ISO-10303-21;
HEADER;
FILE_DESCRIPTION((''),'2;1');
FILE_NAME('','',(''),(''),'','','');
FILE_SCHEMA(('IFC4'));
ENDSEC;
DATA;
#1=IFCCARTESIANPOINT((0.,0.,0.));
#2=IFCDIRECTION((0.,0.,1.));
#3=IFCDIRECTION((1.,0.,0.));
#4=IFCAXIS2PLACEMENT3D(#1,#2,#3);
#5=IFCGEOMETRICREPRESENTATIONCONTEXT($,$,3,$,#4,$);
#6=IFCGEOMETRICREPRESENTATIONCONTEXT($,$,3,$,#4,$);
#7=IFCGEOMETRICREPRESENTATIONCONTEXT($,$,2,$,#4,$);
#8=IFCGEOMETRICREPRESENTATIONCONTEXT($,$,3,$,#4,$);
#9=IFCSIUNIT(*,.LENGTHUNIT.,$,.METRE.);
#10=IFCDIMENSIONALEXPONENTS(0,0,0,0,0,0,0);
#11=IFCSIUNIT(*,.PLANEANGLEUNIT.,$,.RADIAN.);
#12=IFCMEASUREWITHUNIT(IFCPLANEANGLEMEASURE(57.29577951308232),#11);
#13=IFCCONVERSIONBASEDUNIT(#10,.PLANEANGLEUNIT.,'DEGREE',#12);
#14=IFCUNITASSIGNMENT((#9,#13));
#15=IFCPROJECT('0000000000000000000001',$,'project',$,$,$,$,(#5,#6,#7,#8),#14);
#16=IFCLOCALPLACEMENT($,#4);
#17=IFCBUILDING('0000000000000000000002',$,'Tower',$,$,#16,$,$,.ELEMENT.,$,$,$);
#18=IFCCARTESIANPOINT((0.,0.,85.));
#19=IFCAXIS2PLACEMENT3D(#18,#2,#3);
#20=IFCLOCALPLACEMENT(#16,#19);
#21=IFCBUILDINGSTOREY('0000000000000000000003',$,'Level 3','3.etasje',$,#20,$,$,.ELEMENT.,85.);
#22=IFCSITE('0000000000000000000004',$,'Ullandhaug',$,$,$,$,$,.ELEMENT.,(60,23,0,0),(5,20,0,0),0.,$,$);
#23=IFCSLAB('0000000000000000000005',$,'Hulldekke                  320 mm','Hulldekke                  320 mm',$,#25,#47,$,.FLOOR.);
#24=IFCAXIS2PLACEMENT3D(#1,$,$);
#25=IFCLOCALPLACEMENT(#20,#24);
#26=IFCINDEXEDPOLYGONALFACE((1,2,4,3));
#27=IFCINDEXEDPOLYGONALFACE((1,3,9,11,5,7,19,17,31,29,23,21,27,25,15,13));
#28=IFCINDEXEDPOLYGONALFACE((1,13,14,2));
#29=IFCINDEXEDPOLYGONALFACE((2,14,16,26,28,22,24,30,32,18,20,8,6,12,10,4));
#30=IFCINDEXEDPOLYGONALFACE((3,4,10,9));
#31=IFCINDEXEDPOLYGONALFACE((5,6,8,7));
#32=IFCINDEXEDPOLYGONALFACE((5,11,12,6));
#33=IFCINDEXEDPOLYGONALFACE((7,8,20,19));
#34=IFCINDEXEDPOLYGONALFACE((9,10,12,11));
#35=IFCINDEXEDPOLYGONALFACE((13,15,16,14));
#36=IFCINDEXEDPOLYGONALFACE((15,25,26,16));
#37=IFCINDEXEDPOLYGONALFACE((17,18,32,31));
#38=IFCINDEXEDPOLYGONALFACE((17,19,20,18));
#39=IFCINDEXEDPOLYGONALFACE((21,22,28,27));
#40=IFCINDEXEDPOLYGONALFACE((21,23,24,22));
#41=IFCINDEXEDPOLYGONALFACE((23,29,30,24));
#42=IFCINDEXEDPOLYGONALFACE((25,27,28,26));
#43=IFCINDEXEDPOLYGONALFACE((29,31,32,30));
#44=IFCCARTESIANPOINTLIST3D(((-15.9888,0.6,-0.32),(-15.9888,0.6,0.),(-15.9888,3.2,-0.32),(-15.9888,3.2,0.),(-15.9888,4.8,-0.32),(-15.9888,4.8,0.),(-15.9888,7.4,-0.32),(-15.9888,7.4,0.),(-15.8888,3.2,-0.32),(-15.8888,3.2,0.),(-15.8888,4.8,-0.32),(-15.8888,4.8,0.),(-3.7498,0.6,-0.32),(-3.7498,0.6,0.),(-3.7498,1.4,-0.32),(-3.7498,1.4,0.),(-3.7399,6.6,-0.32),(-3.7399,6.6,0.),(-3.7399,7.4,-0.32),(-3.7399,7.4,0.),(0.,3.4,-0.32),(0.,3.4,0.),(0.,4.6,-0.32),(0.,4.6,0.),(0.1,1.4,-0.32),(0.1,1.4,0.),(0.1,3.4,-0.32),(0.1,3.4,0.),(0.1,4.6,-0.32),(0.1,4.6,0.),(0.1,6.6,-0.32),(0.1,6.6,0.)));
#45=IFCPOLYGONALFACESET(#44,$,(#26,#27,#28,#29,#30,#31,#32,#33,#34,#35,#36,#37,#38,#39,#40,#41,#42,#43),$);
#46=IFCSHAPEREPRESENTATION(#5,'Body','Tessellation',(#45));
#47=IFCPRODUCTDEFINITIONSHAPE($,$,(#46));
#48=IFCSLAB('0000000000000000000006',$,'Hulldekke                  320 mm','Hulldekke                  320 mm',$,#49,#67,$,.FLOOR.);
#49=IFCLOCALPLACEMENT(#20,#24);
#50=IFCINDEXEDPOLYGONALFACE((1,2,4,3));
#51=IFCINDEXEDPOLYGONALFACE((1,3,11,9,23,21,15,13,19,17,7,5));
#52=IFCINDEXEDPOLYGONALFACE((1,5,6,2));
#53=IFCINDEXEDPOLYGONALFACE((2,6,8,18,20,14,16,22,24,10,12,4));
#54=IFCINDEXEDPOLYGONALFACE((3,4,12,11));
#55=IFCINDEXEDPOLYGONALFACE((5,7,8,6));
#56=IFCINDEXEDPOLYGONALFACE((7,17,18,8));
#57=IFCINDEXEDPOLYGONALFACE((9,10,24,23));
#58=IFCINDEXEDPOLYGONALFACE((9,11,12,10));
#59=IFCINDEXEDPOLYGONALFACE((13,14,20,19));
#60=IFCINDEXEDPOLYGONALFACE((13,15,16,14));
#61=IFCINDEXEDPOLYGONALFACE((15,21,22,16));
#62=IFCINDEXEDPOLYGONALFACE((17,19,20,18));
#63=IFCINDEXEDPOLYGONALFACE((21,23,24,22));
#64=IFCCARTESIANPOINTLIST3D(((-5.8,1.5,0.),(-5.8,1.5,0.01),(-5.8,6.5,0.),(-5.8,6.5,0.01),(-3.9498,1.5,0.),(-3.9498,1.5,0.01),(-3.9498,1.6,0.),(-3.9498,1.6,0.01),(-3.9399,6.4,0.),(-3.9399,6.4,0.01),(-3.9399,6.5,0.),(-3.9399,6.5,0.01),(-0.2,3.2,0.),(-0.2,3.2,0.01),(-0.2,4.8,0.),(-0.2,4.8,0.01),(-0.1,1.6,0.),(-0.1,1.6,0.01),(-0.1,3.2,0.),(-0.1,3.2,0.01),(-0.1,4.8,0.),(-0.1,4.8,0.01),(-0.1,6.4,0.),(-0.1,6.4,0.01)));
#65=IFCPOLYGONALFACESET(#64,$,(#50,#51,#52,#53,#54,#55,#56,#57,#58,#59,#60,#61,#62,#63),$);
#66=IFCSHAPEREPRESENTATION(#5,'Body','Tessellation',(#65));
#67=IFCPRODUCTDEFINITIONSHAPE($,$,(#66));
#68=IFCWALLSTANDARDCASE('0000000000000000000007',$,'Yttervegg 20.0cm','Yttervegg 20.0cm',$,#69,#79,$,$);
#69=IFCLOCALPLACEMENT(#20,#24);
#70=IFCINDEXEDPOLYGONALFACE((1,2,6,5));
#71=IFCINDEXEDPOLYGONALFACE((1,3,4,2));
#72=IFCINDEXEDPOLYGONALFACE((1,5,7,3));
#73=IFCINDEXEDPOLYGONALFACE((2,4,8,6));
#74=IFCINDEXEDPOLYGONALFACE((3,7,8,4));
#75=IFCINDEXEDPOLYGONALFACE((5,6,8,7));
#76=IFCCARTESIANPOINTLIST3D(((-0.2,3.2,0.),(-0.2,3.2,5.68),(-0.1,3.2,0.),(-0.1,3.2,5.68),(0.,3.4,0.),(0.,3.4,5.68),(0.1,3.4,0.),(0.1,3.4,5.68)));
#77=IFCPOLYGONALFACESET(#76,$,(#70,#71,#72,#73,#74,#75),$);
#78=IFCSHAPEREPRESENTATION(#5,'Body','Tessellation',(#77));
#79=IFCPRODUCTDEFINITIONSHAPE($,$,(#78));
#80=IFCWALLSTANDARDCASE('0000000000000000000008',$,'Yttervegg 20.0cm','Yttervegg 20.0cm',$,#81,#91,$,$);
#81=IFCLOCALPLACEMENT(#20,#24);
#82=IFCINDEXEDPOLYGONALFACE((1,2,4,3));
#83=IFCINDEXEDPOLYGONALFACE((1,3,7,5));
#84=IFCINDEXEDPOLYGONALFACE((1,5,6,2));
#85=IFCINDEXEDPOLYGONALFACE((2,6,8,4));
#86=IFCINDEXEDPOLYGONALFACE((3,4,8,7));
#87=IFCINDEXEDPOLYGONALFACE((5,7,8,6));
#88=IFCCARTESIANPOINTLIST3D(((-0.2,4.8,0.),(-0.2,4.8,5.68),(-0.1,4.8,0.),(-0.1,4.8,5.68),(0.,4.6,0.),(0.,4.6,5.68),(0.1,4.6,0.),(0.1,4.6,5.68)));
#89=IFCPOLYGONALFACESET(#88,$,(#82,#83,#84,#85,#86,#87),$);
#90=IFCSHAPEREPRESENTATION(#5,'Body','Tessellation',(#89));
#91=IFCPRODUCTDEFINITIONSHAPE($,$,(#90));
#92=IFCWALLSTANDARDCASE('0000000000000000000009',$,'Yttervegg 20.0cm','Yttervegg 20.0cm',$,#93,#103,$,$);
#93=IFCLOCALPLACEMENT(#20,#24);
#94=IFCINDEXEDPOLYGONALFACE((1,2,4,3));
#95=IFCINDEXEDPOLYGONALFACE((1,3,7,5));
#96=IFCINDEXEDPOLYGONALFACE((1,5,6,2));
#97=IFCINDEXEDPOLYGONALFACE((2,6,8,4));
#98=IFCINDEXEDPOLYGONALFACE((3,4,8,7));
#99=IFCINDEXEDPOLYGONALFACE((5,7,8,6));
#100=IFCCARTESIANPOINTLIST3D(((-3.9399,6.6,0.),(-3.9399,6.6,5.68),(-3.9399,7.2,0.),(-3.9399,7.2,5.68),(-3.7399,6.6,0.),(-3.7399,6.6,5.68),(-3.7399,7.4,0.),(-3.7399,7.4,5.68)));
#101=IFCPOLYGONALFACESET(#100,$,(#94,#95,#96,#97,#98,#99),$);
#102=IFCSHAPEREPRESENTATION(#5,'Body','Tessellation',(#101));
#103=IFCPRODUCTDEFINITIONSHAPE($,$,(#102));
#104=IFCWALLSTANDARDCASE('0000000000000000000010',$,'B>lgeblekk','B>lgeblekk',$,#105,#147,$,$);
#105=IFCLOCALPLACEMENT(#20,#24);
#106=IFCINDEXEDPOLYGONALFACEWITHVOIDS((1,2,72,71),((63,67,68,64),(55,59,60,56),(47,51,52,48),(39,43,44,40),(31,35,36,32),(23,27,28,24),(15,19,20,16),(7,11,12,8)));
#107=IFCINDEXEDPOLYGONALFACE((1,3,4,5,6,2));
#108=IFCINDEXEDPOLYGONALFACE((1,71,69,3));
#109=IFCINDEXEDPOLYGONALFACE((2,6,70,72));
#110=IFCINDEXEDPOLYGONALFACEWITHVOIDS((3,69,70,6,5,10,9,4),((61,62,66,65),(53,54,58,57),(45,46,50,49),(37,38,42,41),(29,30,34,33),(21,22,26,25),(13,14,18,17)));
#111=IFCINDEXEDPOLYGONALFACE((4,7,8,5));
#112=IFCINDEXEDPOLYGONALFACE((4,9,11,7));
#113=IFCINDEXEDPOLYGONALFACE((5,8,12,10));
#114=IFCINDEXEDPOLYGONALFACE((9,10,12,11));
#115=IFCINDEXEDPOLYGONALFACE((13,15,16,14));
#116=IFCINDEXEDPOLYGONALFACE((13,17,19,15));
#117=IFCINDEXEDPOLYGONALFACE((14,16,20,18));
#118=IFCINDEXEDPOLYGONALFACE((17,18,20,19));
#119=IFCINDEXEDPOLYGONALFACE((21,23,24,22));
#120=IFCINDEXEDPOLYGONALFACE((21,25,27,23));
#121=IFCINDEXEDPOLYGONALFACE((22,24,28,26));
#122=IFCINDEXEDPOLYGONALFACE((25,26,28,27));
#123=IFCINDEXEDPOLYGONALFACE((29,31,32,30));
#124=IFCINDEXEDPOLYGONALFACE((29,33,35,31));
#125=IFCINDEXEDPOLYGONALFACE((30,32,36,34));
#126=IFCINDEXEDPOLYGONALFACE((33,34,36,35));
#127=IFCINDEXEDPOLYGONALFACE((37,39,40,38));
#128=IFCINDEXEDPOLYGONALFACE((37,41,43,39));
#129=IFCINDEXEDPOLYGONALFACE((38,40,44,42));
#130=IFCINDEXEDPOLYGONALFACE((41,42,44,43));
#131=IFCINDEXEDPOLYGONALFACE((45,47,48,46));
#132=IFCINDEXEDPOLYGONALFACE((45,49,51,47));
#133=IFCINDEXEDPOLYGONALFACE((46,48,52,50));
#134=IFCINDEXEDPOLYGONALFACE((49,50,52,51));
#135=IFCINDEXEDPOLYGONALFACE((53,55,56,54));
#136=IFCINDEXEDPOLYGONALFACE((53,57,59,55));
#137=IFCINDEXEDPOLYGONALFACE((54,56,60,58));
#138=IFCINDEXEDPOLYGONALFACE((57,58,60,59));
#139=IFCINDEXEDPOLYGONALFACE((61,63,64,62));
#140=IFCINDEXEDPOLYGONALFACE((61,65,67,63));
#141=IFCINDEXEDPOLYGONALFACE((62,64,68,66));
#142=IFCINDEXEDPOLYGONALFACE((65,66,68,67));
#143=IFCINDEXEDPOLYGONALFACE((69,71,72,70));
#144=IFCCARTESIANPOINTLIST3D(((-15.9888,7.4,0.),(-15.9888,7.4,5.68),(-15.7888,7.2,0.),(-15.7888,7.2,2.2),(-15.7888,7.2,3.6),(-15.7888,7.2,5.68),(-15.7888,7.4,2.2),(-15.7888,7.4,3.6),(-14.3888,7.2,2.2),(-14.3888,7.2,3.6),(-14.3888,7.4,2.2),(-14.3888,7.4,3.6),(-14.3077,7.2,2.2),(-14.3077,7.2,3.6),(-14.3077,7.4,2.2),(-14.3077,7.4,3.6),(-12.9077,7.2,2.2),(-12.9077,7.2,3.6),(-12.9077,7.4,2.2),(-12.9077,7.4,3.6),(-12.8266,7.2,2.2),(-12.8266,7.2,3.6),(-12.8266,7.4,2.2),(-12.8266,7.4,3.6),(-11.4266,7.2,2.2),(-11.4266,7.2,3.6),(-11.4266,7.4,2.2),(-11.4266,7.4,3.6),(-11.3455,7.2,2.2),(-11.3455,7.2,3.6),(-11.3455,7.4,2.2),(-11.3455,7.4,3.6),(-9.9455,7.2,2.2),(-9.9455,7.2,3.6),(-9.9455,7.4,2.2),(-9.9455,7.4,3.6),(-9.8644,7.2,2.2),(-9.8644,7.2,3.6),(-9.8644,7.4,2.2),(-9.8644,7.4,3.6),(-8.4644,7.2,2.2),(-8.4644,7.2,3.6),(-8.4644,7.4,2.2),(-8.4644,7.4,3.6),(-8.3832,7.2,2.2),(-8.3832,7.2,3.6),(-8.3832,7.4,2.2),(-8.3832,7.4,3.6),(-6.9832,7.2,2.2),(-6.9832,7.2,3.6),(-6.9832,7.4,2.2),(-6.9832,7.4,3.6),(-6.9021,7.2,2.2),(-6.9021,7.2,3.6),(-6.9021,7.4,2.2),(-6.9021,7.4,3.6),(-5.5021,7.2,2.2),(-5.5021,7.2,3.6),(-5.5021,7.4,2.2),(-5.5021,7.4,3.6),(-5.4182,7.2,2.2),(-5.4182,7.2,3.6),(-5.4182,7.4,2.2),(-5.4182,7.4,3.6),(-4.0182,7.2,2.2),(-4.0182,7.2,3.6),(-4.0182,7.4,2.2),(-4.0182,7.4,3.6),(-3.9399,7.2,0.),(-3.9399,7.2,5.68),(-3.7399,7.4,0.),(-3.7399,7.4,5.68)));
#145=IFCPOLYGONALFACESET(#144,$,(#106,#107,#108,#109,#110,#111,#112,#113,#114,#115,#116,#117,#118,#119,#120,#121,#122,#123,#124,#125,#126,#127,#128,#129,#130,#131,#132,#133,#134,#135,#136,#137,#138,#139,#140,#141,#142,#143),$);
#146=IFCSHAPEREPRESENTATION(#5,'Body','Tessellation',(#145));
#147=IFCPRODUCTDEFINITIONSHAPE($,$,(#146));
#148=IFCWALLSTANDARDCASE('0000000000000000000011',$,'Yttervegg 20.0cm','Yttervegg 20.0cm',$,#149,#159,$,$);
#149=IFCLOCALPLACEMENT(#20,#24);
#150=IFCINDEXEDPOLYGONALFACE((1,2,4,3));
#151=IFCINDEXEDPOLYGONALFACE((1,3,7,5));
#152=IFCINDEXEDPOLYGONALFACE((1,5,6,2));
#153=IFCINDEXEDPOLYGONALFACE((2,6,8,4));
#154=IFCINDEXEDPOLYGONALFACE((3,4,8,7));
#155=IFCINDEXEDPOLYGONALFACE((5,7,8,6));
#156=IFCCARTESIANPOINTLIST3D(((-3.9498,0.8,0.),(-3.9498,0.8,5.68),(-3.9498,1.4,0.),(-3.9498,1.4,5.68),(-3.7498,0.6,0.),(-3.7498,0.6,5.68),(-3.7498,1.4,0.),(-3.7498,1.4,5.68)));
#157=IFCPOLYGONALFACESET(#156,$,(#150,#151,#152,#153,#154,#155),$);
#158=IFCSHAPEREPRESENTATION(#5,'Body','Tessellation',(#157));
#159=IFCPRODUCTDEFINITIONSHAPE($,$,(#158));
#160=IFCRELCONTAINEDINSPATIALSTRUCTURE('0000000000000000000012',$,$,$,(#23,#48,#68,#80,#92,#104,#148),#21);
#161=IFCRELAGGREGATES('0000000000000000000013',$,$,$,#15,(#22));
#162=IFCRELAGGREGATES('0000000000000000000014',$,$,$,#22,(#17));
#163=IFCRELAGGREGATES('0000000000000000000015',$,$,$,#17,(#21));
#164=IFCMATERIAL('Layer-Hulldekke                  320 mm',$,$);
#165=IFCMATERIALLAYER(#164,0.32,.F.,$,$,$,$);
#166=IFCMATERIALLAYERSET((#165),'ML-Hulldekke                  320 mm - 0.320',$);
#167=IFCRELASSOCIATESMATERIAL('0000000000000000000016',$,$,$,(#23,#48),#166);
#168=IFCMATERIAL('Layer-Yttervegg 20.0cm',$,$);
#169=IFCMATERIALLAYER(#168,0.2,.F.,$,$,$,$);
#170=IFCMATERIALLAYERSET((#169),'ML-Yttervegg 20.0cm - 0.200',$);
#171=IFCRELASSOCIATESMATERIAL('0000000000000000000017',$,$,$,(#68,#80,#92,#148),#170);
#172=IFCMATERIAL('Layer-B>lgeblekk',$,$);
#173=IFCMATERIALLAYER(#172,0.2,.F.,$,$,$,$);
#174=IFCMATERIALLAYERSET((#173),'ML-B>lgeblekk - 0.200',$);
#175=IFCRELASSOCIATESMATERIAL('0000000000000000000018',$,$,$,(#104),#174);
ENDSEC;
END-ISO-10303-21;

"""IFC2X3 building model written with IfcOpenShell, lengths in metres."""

from ifc_helpers import new_model, entity, si_unit, converted_unit, frame, origin_with_axes, place, context, project, spatial, polyline, outline, extrude, material, layer, layer_set, layer_usage, element, save


model = new_model("IFC2X3")

# Units and contexts
context_of_model_1 = context(None, 3, world=origin_with_axes())
context_of_model_2 = context(None, 3, world=origin_with_axes())
context_of_model_3 = context(None, 2, world=origin_with_axes())
context_of_model_4 = context(None, 3, world=origin_with_axes())
ifc_project = project(units=[si_unit("LENGTHUNIT", "METRE"), converted_unit("PLANEANGLEUNIT", "DEGREE", entity("IfcPlaneAngleMeasure", 57.29577951308232), si_unit("PLANEANGLEUNIT", "RADIAN"), dimensions=[0, 0, 0, 0, 0, 0, 0])], contexts=[context_of_model_1, context_of_model_2, context_of_model_3, context_of_model_4])

# Site, building, storey
site = spatial("IfcSite", under=ifc_project, Name="Ullandhaug", CompositionType="ELEMENT", RefLatitude=(60, 23, 0, 0), RefLongitude=(5, 20, 0, 0), RefElevation=0.0)
building_placement = place(None, origin_with_axes())
building = spatial("IfcBuilding", under=site, at=building_placement, Name="Tower", CompositionType="ELEMENT")
storey_placement = place(building_placement, frame((0.0, 0.0, 85.0), z_axis=(0.0, 0.0, 1.0), x_axis=(1.0, 0.0, 0.0)))
storey = spatial("IfcBuildingStorey", under=building, at=storey_placement, Name="Level 3", Description="3.etasje", CompositionType="ELEMENT", Elevation=85.0)

# Slabs
ifc_material_1 = material(Name="Layer-Hulldekke                  320 mm")
ifc_layer_1 = layer(ifc_material_1, 0.32, ventilated=False)
ifc_layer_set_1 = layer_set([ifc_layer_1], Name="ML-Hulldekke                  320 mm - 0.320")
ifc_layer_usage_1 = layer_usage(ifc_layer_set_1, "AXIS2", "POSITIVE", 0.0)
slab_1_placement = place(storey_placement, frame((0.1, 1.4, 0.0), z_axis=(0.0, 0.0, 1.0), x_axis=(1.0, 0.0, 0.0)))
element("IfcSlab", 1, at=slab_1_placement, inside=storey, material=ifc_layer_usage_1, Name="Hulldekke                  320 mm", Description="Hulldekke                  320 mm", PredefinedType="FLOOR", context=context_of_model_1, shape_type="SweptSolid", body=[
    extrude(outline(polyline([(0.0, 0.0), (2.0, 0.0), (2.0, 0.1), (3.2, 0.1), (3.2, 0.0), (5.2, 0.0), (5.2, 3.8399), (6.0, 3.8399), (6.0, 16.0888), (3.4, 16.0888), (3.4, 15.9888), (1.8, 15.9888), (1.8, 16.0888), (-0.8, 16.0888), (-0.8, 3.8498), (0.0, 3.8498), (0.0, 0.0)])), frame((0.0, 0.0, 0.0), z_axis=(0.0, 0.0, 1.0), x_axis=(0.0, 1.0, 0.0)), (0.0, 0.0, -1.0), 0.32),
])
slab_2_placement = place(storey_placement, frame((-0.1, 1.6, 0.0), z_axis=(0.0, 0.0, 1.0), x_axis=(1.0, 0.0, 0.0)))
element("IfcSlab", 2, at=slab_2_placement, inside=storey, material=ifc_layer_usage_1, Name="Hulldekke                  320 mm", Description="Hulldekke                  320 mm", PredefinedType="FLOOR", context=context_of_model_1, shape_type="SweptSolid", body=[
    extrude(outline(polyline([(0.0, 0.0), (1.6, 0.0), (1.6, 0.1), (3.2, 0.1), (3.2, 0.0), (4.8, 0.0), (4.8, 3.8399), (4.9, 3.8399), (4.9, 5.7), (-0.1, 5.7), (-0.1, 3.8498), (0.0, 3.8498), (0.0, 0.0)])), frame((0.0, 0.0, 0.0), z_axis=(0.0, 0.0, 1.0), x_axis=(0.0, 1.0, 0.0)), (0.0, 0.0, 1.0), 0.01),
])

# Walls
ifc_material_2 = material(Name="Layer-Yttervegg 20.0cm")
ifc_layer_2 = layer(ifc_material_2, 0.2, ventilated=False)
ifc_layer_set_2 = layer_set([ifc_layer_2], Name="ML-Yttervegg 20.0cm - 0.200")
ifc_layer_usage_2 = layer_usage(ifc_layer_set_2, "AXIS2", "POSITIVE", 0.0)
wall_1_placement = place(storey_placement, frame((0.1, 3.4, 0.0), z_axis=(0.0, 0.0, 1.0), x_axis=(-1.0, 0.0, 0.0)))
element("IfcWallStandardCase", 3, at=wall_1_placement, inside=storey, material=ifc_layer_usage_2, Name="Yttervegg 20.0cm", Description="Yttervegg 20.0cm", context=context_of_model_1, shape_type="SweptSolid", body=[
    extrude(outline(polyline([(0.0, 0.0), (0.1, 0.0), (0.3, 0.2), (0.2, 0.2), (0.0, 0.0)])), frame((0.0, 0.0, 0.0), z_axis=(0.0, 0.0, 1.0), x_axis=(1.0, 0.0, 0.0)), (0.0, 0.0, 1.0), 5.68),
])
wall_2_placement = place(storey_placement, frame((0.0, 4.6, 0.0), z_axis=(0.0, 0.0, 1.0), x_axis=(1.0, 0.0, 0.0)))
element("IfcWallStandardCase", 4, at=wall_2_placement, inside=storey, material=ifc_layer_usage_2, Name="Yttervegg 20.0cm", Description="Yttervegg 20.0cm", context=context_of_model_1, shape_type="SweptSolid", body=[
    extrude(outline(polyline([(0.0, 0.0), (0.1, 0.0), (-0.1, 0.2), (-0.2, 0.2), (0.0, 0.0)])), origin_with_axes(), (0.0, 0.0, 1.0), 5.68),
])
wall_3_placement = place(storey_placement, frame((-3.7399, 6.6, 0.0), z_axis=(0.0, 0.0, 1.0), x_axis=(0.0, 1.0, 0.0)))
element("IfcWallStandardCase", 5, at=wall_3_placement, inside=storey, material=ifc_layer_usage_2, Name="Yttervegg 20.0cm", Description="Yttervegg 20.0cm", context=context_of_model_1, shape_type="SweptSolid", body=[
    extrude(outline(polyline([(0.0, 0.0), (0.8, 0.0), (0.6, 0.2), (0.0, 0.2), (0.0, 0.0)])), frame((0.0, 0.0, 0.0), z_axis=(0.0, 0.0, 1.0), x_axis=(1.0, 0.0, 0.0)), (0.0, 0.0, 1.0), 5.68),
])

# Wall, openings
ifc_material_3 = material(Name="Layer-B>lgeblekk")
ifc_layer_3 = layer(ifc_material_3, 0.2, ventilated=False)
ifc_layer_set_3 = layer_set([ifc_layer_3], Name="ML-B>lgeblekk - 0.200")
ifc_layer_usage_3 = layer_usage(ifc_layer_set_3, "AXIS2", "POSITIVE", 0.0)
wall_4_placement = place(storey_placement, frame((-3.7399, 7.4, 0.0), z_axis=(0.0, 0.0, 1.0), x_axis=(-1.0, 0.0, 0.0)))
wall_4 = element("IfcWallStandardCase", 6, at=wall_4_placement, inside=storey, material=ifc_layer_usage_3, Name="B>lgeblekk", Description="B>lgeblekk", context=context_of_model_1, shape_type="SweptSolid", body=[
    extrude(outline(polyline([(0.0, 0.0), (12.2489, 0.0), (12.0489, 0.2), (0.2, 0.2), (0.0, 0.0)])), frame((0.0, 0.0, 0.0), z_axis=(0.0, 0.0, 1.0), x_axis=(1.0, 0.0, 0.0)), (0.0, 0.0, 1.0), 5.68),
])
opening_1_placement = place(wall_4_placement, frame((10.6489, 0.2, 2.2), z_axis=(0.0, 0.0, 1.0), x_axis=(1.0, 0.0, 0.0)))
element("IfcOpeningElement", 7, at=opening_1_placement, cuts=wall_4, context=context_of_model_1, shape_type="SweptSolid", body=[
    extrude(outline(polyline([(0.0, 0.0), (1.4, 0.0), (1.4, 1.4), (0.0, 1.4), (0.0, 0.0)])), frame((0.0, 0.0, 0.0), z_axis=(0.0, 1.0, 0.0), x_axis=(0.0, 0.0, 1.0)), (0.0, 0.0, -1.0), 0.2),
])
opening_2_placement = place(wall_4_placement, frame((9.1678, 0.2, 2.2), z_axis=(0.0, 0.0, 1.0), x_axis=(1.0, 0.0, 0.0)))
element("IfcOpeningElement", 8, at=opening_2_placement, cuts=wall_4, context=context_of_model_1, shape_type="SweptSolid", body=[
    extrude(outline(polyline([(0.0, 0.0), (1.4, 0.0), (1.4, 1.4), (0.0, 1.4), (0.0, 0.0)])), frame((0.0, 0.0, 0.0), z_axis=(0.0, 1.0, 0.0), x_axis=(0.0, 0.0, 1.0)), (0.0, 0.0, -1.0), 0.2),
])
opening_3_placement = place(wall_4_placement, frame((7.6867, 0.2, 2.2), z_axis=(0.0, 0.0, 1.0), x_axis=(1.0, 0.0, 0.0)))
element("IfcOpeningElement", 9, at=opening_3_placement, cuts=wall_4, context=context_of_model_1, shape_type="SweptSolid", body=[
    extrude(outline(polyline([(0.0, 0.0), (1.4, 0.0), (1.4, 1.4), (0.0, 1.4), (0.0, 0.0)])), frame((0.0, 0.0, 0.0), z_axis=(0.0, 1.0, 0.0), x_axis=(0.0, 0.0, 1.0)), (0.0, 0.0, -1.0), 0.2),
])
opening_4_placement = place(wall_4_placement, frame((6.2056, 0.2, 2.2), z_axis=(0.0, 0.0, 1.0), x_axis=(1.0, 0.0, 0.0)))
element("IfcOpeningElement", 10, at=opening_4_placement, cuts=wall_4, context=context_of_model_1, shape_type="SweptSolid", body=[
    extrude(outline(polyline([(0.0, 0.0), (1.4, 0.0), (1.4, 1.4), (0.0, 1.4), (0.0, 0.0)])), frame((0.0, 0.0, 0.0), z_axis=(0.0, 1.0, 0.0), x_axis=(0.0, 0.0, 1.0)), (0.0, 0.0, -1.0), 0.2),
])
opening_5_placement = place(wall_4_placement, frame((4.7245, 0.2, 2.2), z_axis=(0.0, 0.0, 1.0), x_axis=(1.0, 0.0, 0.0)))
element("IfcOpeningElement", 11, at=opening_5_placement, cuts=wall_4, context=context_of_model_1, shape_type="SweptSolid", body=[
    extrude(outline(polyline([(0.0, 0.0), (1.4, 0.0), (1.4, 1.4), (0.0, 1.4), (0.0, 0.0)])), frame((0.0, 0.0, 0.0), z_axis=(0.0, 1.0, 0.0), x_axis=(0.0, 0.0, 1.0)), (0.0, 0.0, -1.0), 0.2),
])
opening_6_placement = place(wall_4_placement, frame((3.2434, 0.2, 2.2), z_axis=(0.0, 0.0, 1.0), x_axis=(1.0, 0.0, 0.0)))
element("IfcOpeningElement", 12, at=opening_6_placement, cuts=wall_4, context=context_of_model_1, shape_type="SweptSolid", body=[
    extrude(outline(polyline([(0.0, 0.0), (1.4, 0.0), (1.4, 1.4), (0.0, 1.4), (0.0, 0.0)])), frame((0.0, 0.0, 0.0), z_axis=(0.0, 1.0, 0.0), x_axis=(0.0, 0.0, 1.0)), (0.0, 0.0, -1.0), 0.2),
])
opening_7_placement = place(wall_4_placement, frame((1.7622, 0.2, 2.2), z_axis=(0.0, 0.0, 1.0), x_axis=(1.0, 0.0, 0.0)))
element("IfcOpeningElement", 13, at=opening_7_placement, cuts=wall_4, context=context_of_model_1, shape_type="SweptSolid", body=[
    extrude(outline(polyline([(0.0, 0.0), (1.4, 0.0), (1.4, 1.4), (0.0, 1.4), (0.0, 0.0)])), frame((0.0, 0.0, 0.0), z_axis=(0.0, 1.0, 0.0), x_axis=(0.0, 0.0, 1.0)), (0.0, 0.0, -1.0), 0.2),
])
opening_8_placement = place(wall_4_placement, frame((0.2783, 0.2, 2.2), z_axis=(0.0, 0.0, 1.0), x_axis=(1.0, 0.0, 0.0)))
element("IfcOpeningElement", 14, at=opening_8_placement, cuts=wall_4, context=context_of_model_1, shape_type="SweptSolid", body=[
    extrude(outline(polyline([(0.0, 0.0), (1.4, 0.0), (1.4, 1.4), (0.0, 1.4), (0.0, 0.0)])), frame((0.0, 0.0, 0.0), z_axis=(0.0, 1.0, 0.0), x_axis=(0.0, 0.0, 1.0)), (0.0, 0.0, -1.0), 0.2),
])

# Wall
wall_5_placement = place(storey_placement, frame((-3.7498, 0.6, 0.0), z_axis=(0.0, 0.0, 1.0), x_axis=(0.0, 1.0, 0.0)))
element("IfcWallStandardCase", 15, at=wall_5_placement, inside=storey, material=ifc_layer_usage_2, Name="Yttervegg 20.0cm", Description="Yttervegg 20.0cm", context=context_of_model_1, shape_type="SweptSolid", body=[
    extrude(outline(polyline([(0.0, 0.0), (0.8, 0.0), (0.8, 0.2), (0.2, 0.2), (0.0, 0.0)])), frame((0.0, 0.0, 0.0), z_axis=(0.0, 0.0, 1.0), x_axis=(1.0, 0.0, 0.0)), (0.0, 0.0, 1.0), 5.68),
])

save(model, "model.ifc")
